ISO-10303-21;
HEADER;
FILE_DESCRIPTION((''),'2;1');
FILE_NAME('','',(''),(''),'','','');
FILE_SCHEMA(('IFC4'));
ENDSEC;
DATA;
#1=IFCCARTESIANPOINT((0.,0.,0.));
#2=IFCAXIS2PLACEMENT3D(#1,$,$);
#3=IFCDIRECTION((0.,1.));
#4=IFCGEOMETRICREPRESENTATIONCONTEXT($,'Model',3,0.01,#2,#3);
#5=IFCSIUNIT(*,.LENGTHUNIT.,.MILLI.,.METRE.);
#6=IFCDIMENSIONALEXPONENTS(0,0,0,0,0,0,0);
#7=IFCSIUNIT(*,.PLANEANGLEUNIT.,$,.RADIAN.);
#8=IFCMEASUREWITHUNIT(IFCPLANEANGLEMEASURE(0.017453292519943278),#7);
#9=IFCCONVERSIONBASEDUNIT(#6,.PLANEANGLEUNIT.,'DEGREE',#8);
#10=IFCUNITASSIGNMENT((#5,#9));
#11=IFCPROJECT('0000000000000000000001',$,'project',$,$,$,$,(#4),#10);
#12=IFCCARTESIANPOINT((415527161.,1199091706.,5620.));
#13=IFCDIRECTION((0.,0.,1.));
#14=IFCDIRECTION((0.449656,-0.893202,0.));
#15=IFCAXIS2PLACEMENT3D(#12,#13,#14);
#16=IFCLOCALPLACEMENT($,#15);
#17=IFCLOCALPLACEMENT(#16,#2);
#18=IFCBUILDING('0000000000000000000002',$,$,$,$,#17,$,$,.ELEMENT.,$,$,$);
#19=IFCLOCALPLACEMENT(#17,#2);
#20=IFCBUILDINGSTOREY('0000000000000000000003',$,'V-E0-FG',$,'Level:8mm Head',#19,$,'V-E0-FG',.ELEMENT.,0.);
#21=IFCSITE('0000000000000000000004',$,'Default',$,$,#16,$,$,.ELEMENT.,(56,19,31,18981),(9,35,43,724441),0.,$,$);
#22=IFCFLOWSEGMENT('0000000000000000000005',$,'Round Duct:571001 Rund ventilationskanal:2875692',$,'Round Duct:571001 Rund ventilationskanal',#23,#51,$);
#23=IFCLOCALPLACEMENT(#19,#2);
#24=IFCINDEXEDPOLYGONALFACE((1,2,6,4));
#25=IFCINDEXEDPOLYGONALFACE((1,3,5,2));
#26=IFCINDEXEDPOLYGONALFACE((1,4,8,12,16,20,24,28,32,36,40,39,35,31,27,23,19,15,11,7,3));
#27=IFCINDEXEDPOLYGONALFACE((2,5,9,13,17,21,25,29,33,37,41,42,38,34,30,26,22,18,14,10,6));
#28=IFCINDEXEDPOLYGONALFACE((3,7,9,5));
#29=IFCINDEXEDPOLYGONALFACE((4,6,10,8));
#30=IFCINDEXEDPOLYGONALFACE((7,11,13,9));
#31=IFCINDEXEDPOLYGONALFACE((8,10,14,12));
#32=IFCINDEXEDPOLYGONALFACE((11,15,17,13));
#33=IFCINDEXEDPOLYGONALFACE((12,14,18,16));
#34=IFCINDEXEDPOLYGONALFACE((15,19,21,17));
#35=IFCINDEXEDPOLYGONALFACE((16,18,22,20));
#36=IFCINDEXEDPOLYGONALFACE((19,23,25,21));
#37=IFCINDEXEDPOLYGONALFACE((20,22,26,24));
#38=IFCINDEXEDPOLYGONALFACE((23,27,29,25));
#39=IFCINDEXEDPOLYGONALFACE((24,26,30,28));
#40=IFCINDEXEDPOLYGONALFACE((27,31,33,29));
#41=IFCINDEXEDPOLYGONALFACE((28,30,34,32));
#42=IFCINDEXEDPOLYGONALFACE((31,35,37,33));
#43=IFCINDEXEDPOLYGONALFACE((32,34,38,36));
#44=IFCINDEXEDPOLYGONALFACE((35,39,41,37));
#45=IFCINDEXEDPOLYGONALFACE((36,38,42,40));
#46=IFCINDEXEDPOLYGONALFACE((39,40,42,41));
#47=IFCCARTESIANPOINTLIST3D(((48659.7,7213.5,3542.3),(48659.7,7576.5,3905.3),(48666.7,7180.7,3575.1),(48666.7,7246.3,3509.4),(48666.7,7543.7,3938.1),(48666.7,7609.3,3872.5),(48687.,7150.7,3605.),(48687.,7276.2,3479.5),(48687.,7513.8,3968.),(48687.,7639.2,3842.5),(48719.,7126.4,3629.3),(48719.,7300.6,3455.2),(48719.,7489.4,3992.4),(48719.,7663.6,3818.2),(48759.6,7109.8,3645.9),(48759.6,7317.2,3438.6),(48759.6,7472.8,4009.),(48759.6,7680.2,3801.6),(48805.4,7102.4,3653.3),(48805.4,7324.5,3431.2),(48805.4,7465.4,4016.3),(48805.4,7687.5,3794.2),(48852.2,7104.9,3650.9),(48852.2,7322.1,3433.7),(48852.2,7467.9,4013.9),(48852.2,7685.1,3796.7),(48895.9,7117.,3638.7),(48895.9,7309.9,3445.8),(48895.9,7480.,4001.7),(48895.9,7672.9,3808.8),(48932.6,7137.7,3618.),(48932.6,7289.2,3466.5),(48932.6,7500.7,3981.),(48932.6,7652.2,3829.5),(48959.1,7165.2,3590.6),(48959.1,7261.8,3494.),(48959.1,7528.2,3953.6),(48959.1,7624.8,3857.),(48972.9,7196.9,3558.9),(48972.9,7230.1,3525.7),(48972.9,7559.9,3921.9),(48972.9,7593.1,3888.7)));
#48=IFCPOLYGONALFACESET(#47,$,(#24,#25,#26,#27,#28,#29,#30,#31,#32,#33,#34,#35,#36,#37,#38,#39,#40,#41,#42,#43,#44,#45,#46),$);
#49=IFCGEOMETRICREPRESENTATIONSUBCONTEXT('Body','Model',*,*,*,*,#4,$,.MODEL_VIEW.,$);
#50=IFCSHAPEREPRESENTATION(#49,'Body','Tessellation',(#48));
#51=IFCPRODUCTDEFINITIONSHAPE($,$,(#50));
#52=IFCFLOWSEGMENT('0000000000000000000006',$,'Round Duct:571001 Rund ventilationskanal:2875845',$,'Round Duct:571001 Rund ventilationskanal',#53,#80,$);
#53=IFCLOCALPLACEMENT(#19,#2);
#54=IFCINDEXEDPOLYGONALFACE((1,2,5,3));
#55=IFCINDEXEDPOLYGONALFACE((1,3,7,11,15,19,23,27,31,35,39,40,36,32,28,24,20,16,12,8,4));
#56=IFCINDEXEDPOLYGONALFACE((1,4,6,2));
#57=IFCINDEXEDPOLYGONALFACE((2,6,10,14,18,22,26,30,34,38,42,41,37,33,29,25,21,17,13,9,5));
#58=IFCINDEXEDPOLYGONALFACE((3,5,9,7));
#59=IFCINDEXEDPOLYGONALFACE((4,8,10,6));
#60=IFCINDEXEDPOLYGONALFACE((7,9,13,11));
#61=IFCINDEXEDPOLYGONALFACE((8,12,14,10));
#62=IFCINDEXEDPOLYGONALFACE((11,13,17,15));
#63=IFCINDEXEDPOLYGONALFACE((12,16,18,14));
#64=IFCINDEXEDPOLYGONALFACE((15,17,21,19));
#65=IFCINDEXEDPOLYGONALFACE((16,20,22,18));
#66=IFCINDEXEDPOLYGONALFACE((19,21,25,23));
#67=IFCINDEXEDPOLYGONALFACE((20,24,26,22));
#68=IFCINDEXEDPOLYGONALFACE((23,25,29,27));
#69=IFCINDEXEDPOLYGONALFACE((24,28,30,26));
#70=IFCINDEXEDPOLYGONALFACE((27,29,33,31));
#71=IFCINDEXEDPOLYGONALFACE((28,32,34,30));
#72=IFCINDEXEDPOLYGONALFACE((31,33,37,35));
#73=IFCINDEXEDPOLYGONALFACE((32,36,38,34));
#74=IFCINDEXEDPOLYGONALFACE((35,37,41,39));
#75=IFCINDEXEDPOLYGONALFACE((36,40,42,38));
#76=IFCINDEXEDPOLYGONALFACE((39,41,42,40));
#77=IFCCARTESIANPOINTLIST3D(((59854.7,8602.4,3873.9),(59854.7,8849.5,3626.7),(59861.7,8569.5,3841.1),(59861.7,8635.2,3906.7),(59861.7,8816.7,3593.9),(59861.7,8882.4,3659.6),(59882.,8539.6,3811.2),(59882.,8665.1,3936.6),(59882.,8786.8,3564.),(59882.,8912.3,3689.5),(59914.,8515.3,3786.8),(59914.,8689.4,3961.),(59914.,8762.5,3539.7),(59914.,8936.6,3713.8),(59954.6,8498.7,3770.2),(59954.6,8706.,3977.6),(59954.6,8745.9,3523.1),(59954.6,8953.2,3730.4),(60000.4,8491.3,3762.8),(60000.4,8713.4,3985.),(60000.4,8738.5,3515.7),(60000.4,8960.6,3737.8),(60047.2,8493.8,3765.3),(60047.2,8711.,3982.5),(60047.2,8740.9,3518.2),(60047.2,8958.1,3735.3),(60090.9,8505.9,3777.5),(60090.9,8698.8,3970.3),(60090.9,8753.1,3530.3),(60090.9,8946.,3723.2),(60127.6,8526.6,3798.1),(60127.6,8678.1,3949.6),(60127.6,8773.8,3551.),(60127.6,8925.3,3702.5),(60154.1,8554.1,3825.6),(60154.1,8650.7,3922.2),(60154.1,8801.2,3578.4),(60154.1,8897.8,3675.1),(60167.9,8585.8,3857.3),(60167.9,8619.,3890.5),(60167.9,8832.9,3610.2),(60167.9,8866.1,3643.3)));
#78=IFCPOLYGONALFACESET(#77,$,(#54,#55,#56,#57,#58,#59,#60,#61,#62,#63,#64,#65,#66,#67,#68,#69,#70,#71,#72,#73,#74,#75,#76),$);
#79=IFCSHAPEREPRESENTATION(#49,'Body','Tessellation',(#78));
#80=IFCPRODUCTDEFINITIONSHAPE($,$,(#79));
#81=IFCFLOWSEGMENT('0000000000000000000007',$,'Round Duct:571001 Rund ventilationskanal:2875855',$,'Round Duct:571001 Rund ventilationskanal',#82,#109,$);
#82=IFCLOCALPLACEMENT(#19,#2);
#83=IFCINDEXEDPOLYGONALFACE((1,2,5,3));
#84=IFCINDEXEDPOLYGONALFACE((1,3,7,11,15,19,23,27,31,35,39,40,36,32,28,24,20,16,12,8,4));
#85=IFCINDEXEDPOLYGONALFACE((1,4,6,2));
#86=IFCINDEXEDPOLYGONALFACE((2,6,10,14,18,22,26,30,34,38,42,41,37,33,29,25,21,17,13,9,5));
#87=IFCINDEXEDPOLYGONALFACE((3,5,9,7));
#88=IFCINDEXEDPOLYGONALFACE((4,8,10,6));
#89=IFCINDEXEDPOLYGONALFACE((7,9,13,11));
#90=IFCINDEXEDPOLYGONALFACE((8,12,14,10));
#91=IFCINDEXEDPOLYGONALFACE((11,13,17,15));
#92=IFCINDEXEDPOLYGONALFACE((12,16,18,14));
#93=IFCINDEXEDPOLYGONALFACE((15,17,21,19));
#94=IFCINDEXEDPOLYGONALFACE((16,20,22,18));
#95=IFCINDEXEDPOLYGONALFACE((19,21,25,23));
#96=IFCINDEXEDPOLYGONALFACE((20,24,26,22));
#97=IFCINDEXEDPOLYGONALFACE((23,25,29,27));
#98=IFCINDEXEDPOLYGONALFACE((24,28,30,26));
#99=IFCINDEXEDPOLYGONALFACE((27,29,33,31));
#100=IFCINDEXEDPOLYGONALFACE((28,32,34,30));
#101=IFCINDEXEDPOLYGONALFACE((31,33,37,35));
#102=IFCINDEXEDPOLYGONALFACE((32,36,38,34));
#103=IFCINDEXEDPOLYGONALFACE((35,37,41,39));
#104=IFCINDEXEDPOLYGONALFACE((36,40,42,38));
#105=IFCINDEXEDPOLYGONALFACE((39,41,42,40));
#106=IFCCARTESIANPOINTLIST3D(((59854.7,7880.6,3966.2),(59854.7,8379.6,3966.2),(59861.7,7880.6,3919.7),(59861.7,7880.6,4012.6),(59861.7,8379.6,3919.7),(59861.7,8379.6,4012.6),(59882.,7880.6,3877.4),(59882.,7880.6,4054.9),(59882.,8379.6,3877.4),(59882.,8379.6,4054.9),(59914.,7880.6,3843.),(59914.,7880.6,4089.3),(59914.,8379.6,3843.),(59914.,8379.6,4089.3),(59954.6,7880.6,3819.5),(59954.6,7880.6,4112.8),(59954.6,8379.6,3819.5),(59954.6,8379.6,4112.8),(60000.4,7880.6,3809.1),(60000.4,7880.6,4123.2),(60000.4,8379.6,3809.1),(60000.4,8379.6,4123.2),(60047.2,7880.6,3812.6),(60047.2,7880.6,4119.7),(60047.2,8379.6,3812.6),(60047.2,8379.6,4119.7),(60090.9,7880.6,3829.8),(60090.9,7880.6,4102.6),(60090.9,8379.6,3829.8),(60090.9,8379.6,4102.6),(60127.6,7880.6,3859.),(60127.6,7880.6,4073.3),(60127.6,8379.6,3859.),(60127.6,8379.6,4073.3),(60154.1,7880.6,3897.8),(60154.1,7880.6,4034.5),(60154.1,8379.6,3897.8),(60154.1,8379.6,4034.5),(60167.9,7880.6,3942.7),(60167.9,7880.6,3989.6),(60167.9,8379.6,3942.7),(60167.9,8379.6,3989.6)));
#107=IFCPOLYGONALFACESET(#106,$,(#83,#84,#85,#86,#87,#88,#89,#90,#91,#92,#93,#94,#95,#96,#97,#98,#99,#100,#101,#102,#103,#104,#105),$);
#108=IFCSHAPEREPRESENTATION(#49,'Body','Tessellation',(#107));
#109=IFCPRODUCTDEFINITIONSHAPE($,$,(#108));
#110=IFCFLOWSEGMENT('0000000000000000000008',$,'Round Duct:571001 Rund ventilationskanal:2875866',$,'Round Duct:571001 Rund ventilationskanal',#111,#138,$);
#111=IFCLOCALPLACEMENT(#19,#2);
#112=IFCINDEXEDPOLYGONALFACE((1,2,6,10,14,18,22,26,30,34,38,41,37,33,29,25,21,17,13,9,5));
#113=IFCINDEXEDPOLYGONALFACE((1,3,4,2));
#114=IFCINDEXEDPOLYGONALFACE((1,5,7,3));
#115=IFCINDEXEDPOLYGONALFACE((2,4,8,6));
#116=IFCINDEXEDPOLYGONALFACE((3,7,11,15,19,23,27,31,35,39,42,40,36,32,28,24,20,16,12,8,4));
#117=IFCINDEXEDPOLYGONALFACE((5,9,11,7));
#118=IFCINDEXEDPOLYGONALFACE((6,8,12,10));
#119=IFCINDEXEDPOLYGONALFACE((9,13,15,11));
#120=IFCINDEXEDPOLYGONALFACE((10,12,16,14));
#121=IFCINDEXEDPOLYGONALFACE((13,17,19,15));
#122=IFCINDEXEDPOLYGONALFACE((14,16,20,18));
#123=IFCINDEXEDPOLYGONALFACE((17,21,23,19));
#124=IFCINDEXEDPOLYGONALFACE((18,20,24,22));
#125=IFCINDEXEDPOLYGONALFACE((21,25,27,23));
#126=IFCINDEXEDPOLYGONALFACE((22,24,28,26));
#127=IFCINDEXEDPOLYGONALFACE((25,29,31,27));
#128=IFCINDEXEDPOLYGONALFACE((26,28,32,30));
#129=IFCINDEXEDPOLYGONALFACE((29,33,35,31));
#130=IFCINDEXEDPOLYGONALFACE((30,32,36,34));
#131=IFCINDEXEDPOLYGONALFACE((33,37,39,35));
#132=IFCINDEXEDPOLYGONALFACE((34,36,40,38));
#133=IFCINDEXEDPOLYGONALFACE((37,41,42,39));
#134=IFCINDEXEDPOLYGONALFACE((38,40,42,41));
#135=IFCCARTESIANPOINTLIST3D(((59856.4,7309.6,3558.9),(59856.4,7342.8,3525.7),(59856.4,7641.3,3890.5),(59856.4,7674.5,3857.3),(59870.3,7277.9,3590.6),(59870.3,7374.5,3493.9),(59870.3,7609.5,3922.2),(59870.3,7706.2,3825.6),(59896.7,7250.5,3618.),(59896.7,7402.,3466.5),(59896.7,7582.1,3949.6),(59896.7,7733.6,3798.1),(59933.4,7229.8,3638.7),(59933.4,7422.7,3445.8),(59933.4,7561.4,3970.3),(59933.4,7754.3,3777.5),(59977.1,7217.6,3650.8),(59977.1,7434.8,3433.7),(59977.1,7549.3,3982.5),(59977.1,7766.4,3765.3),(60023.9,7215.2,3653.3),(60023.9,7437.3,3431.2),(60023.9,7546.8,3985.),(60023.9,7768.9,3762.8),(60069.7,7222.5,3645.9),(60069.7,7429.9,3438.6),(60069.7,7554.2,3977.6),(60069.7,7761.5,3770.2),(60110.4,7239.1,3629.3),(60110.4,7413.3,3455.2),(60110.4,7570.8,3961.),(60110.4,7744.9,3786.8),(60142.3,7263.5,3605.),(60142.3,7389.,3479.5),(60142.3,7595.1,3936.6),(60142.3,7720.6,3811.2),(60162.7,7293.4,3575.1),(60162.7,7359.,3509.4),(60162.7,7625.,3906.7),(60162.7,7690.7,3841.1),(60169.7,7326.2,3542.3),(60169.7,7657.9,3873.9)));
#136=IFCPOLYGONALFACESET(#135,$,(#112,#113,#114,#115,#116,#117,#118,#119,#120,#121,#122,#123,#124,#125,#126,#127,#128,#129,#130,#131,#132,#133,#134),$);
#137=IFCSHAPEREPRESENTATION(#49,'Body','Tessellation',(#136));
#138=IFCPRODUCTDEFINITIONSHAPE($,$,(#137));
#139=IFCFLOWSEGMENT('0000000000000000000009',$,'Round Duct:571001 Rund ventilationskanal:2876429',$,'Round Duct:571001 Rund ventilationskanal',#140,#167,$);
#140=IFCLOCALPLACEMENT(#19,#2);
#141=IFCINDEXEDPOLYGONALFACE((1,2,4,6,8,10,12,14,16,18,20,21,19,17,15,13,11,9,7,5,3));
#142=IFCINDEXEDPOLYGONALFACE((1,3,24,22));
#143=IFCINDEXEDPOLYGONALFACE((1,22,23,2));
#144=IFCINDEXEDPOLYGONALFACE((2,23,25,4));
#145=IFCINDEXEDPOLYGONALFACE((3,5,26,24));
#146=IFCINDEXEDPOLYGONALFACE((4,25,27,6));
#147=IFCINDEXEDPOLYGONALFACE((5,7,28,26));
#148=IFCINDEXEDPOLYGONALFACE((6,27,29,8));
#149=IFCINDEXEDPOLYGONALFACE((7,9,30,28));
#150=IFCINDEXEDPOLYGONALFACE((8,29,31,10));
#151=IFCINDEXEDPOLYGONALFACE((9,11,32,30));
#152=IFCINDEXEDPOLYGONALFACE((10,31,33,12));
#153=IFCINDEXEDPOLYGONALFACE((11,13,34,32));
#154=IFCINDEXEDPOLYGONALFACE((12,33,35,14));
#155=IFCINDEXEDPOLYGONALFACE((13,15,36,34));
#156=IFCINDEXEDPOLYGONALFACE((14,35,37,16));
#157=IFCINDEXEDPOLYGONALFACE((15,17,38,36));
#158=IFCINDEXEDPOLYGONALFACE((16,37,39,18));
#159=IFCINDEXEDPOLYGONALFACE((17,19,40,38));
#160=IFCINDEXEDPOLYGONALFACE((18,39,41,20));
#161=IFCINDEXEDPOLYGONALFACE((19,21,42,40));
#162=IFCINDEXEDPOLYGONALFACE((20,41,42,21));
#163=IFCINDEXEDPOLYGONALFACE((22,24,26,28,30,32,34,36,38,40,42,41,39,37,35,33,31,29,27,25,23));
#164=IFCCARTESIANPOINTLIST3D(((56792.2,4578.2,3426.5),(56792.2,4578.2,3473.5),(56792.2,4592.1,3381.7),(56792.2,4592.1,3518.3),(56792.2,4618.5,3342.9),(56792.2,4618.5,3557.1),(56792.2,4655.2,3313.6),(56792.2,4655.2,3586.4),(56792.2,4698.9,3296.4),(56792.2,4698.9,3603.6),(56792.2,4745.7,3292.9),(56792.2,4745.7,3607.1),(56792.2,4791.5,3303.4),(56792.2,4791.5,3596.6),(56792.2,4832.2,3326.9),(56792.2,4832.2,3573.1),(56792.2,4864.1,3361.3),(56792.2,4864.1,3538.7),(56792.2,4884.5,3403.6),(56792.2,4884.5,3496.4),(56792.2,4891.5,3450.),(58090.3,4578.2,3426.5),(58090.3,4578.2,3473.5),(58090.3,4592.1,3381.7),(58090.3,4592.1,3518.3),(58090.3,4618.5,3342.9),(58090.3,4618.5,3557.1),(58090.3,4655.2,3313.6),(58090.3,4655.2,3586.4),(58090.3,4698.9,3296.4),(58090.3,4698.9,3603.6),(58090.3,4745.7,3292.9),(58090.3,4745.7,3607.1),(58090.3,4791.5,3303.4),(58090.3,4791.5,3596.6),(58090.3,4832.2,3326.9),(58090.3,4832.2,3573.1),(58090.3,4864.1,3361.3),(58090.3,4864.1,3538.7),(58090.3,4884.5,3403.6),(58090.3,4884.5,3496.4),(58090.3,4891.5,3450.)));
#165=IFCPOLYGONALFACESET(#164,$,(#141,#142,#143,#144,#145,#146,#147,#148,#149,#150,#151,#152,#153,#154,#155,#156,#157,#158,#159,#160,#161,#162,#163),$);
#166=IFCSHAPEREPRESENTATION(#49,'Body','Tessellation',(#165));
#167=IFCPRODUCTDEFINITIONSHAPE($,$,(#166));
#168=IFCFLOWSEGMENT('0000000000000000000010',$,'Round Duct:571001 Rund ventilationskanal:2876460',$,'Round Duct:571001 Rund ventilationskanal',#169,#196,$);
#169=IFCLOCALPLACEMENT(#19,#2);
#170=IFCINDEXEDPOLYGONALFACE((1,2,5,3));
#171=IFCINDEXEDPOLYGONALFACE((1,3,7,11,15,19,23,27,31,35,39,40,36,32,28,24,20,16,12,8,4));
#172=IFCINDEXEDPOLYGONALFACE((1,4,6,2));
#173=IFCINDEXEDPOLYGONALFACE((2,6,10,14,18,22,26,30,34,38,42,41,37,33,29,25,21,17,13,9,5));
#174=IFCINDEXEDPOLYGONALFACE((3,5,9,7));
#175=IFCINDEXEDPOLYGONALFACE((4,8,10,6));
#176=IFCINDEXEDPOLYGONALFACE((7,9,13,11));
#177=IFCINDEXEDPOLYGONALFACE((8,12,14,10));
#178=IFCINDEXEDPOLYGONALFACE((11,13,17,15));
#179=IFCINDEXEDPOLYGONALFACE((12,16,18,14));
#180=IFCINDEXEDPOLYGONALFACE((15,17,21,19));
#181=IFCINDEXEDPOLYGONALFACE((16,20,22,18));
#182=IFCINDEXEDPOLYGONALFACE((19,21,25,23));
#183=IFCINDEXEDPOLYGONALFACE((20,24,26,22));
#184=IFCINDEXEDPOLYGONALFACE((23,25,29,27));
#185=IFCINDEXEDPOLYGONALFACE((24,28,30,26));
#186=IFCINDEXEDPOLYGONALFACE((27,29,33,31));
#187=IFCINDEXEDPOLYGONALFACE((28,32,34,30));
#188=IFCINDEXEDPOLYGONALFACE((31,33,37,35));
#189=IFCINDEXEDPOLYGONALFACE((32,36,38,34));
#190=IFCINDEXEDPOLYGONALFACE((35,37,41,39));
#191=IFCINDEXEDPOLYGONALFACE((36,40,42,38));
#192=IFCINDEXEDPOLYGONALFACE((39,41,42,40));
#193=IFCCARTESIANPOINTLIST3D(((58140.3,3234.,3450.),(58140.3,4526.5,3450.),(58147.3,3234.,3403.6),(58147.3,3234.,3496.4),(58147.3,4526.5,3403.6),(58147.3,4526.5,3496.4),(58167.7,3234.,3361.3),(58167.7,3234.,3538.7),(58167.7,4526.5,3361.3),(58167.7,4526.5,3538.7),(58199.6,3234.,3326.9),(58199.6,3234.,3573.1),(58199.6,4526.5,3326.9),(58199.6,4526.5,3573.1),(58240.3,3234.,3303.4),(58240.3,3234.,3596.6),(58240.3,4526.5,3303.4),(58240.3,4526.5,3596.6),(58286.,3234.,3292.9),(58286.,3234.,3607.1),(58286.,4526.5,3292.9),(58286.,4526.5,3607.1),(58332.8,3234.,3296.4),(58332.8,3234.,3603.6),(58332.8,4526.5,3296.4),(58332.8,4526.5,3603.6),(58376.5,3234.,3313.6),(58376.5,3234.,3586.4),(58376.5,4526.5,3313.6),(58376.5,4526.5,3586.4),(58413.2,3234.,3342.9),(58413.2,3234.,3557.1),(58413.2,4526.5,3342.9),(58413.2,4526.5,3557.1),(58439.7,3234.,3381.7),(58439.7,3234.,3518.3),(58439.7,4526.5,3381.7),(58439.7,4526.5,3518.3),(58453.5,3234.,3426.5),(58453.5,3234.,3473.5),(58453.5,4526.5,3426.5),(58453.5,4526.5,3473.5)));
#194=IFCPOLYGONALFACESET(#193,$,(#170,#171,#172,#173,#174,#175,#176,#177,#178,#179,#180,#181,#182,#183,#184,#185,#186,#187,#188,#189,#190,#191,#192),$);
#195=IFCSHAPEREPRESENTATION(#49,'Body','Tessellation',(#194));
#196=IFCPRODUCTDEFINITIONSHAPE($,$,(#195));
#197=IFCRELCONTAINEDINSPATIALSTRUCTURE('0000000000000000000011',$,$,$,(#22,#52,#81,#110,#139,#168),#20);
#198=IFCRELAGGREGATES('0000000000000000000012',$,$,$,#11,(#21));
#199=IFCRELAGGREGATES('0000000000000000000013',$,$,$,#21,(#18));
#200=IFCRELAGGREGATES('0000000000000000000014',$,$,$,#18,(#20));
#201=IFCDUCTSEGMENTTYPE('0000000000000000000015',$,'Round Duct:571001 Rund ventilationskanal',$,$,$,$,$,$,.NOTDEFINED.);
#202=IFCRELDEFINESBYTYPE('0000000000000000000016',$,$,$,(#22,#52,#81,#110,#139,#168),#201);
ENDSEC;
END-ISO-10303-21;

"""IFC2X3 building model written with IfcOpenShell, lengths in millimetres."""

from ifc_helpers import new_model, entity, si_unit, converted_unit, direction, frame, frame_2d, origin, origin_2d_with_axis, place, context, subcontext, project, spatial, circle, extrude, type_object, element, save


model = new_model("IFC2X3")

# Units and contexts
model_context = context("Model", 3, precision=0.01, world=origin(), true_north=direction((0.0, 1.0)))
body_context = subcontext(model_context, "Body", "Model", "MODEL_VIEW")
ifc_project = project(units=[si_unit("LENGTHUNIT", "METRE", prefix="MILLI"), converted_unit("PLANEANGLEUNIT", "DEGREE", entity("IfcPlaneAngleMeasure", 0.017453292519943278), si_unit("PLANEANGLEUNIT", "RADIAN"), dimensions=[0, 0, 0, 0, 0, 0, 0])], contexts=[model_context])

# Site, building, storey
site_placement = place(None, frame((415527161.0, 1199091706.0, 5620.0), z_axis=(0.0, 0.0, 1.0), x_axis=(0.449656, -0.893202, 0.0)))
site = spatial("IfcSite", under=ifc_project, at=site_placement, Name="Default", CompositionType="ELEMENT", RefLatitude=(56, 19, 31, 18981), RefLongitude=(9, 35, 43, 724441), RefElevation=0.0)
building_placement = place(site_placement, origin())
building = spatial("IfcBuilding", under=site, at=building_placement, CompositionType="ELEMENT")
storey_placement = place(building_placement, origin())
storey = spatial("IfcBuildingStorey", under=building, at=storey_placement, Name="V-E0-FG", ObjectType="Level:8mm Head", LongName="V-E0-FG", CompositionType="ELEMENT", Elevation=0.0)

# Flow segments
duct_segment_type = type_object("IfcDuctSegmentType", Name="Round Duct:571001 Rund ventilationskanal", PredefinedType="NOTDEFINED")
flow_segment_1_placement = place(storey_placement, origin())
element("IfcFlowSegment", 1, at=flow_segment_1_placement, inside=storey, type_object=duct_segment_type, Name="Round Duct:571001 Rund ventilationskanal:2875692", ObjectType="Round Duct:571001 Rund ventilationskanal", context=body_context, shape_type="SweptSolid", body=[
    extrude(circle(Radius=157.5, at=frame_2d((0.0, 0.0), x_axis=(1.0, 0.0))), frame((48817.2, 7213.5, 3542.3), z_axis=(0.0, 0.707107, 0.707107), x_axis=(-1.0, 0.0, 0.0)), (0.0, 0.0, 1.0), 513.4),
])
flow_segment_2_placement = place(storey_placement, origin())
element("IfcFlowSegment", 2, at=flow_segment_2_placement, inside=storey, type_object=duct_segment_type, Name="Round Duct:571001 Rund ventilationskanal:2875845", ObjectType="Round Duct:571001 Rund ventilationskanal", context=body_context, shape_type="SweptSolid", body=[
    extrude(circle(Radius=157.5, at=frame_2d((0.0, 0.0), x_axis=(1.0, 0.0))), frame((60012.2, 8849.5, 3626.7), z_axis=(0.0, -0.707107, 0.707107), x_axis=(-1.0, 0.0, 0.0)), (0.0, 0.0, 1.0), 349.5),
])
flow_segment_3_placement = place(storey_placement, origin())
element("IfcFlowSegment", 3, at=flow_segment_3_placement, inside=storey, type_object=duct_segment_type, Name="Round Duct:571001 Rund ventilationskanal:2875855", ObjectType="Round Duct:571001 Rund ventilationskanal", context=body_context, shape_type="SweptSolid", body=[
    extrude(circle(Radius=157.5, at=frame_2d((0.0, 0.0), x_axis=(1.0, 0.0))), frame((60012.2, 7880.6, 3966.2), z_axis=(0.0, 1.0, 0.0), x_axis=(-1.0, 0.0, 0.0)), (0.0, 0.0, 1.0), 499.0),
])
flow_segment_4_placement = place(storey_placement, origin())
element("IfcFlowSegment", 4, at=flow_segment_4_placement, inside=storey, type_object=duct_segment_type, Name="Round Duct:571001 Rund ventilationskanal:2875866", ObjectType="Round Duct:571001 Rund ventilationskanal", context=body_context, shape_type="SweptSolid", body=[
    extrude(circle(Radius=157.5, at=origin_2d_with_axis()), frame((60012.2, 7326.2, 3542.3), z_axis=(0.0, 0.707107, 0.707107), x_axis=(1.0, 0.0, 0.0)), (0.0, 0.0, 1.0), 469.0),
])
flow_segment_5_placement = place(storey_placement, origin())
element("IfcFlowSegment", 5, at=flow_segment_5_placement, inside=storey, type_object=duct_segment_type, Name="Round Duct:571001 Rund ventilationskanal:2876429", ObjectType="Round Duct:571001 Rund ventilationskanal", context=body_context, shape_type="SweptSolid", body=[
    extrude(circle(Radius=157.5, at=frame_2d((0.0, 0.0), x_axis=(1.0, 0.0))), frame((56792.2, 4734.0, 3450.0), z_axis=(1.0, 0.0, 0.0), x_axis=(0.0, 1.0, 0.0)), (0.0, 0.0, 1.0), 1298.1),
])
flow_segment_6_placement = place(storey_placement, origin())
element("IfcFlowSegment", 6, at=flow_segment_6_placement, inside=storey, type_object=duct_segment_type, Name="Round Duct:571001 Rund ventilationskanal:2876460", ObjectType="Round Duct:571001 Rund ventilationskanal", context=body_context, shape_type="SweptSolid", body=[
    extrude(circle(Radius=157.5, at=frame_2d((0.0, 0.0), x_axis=(1.0, 0.0))), frame((58297.8, 3234.0, 3450.0), z_axis=(0.0, 1.0, 0.0), x_axis=(-1.0, 0.0, 0.0)), (0.0, 0.0, 1.0), 1292.5),
])

save(model, "model.ifc")
